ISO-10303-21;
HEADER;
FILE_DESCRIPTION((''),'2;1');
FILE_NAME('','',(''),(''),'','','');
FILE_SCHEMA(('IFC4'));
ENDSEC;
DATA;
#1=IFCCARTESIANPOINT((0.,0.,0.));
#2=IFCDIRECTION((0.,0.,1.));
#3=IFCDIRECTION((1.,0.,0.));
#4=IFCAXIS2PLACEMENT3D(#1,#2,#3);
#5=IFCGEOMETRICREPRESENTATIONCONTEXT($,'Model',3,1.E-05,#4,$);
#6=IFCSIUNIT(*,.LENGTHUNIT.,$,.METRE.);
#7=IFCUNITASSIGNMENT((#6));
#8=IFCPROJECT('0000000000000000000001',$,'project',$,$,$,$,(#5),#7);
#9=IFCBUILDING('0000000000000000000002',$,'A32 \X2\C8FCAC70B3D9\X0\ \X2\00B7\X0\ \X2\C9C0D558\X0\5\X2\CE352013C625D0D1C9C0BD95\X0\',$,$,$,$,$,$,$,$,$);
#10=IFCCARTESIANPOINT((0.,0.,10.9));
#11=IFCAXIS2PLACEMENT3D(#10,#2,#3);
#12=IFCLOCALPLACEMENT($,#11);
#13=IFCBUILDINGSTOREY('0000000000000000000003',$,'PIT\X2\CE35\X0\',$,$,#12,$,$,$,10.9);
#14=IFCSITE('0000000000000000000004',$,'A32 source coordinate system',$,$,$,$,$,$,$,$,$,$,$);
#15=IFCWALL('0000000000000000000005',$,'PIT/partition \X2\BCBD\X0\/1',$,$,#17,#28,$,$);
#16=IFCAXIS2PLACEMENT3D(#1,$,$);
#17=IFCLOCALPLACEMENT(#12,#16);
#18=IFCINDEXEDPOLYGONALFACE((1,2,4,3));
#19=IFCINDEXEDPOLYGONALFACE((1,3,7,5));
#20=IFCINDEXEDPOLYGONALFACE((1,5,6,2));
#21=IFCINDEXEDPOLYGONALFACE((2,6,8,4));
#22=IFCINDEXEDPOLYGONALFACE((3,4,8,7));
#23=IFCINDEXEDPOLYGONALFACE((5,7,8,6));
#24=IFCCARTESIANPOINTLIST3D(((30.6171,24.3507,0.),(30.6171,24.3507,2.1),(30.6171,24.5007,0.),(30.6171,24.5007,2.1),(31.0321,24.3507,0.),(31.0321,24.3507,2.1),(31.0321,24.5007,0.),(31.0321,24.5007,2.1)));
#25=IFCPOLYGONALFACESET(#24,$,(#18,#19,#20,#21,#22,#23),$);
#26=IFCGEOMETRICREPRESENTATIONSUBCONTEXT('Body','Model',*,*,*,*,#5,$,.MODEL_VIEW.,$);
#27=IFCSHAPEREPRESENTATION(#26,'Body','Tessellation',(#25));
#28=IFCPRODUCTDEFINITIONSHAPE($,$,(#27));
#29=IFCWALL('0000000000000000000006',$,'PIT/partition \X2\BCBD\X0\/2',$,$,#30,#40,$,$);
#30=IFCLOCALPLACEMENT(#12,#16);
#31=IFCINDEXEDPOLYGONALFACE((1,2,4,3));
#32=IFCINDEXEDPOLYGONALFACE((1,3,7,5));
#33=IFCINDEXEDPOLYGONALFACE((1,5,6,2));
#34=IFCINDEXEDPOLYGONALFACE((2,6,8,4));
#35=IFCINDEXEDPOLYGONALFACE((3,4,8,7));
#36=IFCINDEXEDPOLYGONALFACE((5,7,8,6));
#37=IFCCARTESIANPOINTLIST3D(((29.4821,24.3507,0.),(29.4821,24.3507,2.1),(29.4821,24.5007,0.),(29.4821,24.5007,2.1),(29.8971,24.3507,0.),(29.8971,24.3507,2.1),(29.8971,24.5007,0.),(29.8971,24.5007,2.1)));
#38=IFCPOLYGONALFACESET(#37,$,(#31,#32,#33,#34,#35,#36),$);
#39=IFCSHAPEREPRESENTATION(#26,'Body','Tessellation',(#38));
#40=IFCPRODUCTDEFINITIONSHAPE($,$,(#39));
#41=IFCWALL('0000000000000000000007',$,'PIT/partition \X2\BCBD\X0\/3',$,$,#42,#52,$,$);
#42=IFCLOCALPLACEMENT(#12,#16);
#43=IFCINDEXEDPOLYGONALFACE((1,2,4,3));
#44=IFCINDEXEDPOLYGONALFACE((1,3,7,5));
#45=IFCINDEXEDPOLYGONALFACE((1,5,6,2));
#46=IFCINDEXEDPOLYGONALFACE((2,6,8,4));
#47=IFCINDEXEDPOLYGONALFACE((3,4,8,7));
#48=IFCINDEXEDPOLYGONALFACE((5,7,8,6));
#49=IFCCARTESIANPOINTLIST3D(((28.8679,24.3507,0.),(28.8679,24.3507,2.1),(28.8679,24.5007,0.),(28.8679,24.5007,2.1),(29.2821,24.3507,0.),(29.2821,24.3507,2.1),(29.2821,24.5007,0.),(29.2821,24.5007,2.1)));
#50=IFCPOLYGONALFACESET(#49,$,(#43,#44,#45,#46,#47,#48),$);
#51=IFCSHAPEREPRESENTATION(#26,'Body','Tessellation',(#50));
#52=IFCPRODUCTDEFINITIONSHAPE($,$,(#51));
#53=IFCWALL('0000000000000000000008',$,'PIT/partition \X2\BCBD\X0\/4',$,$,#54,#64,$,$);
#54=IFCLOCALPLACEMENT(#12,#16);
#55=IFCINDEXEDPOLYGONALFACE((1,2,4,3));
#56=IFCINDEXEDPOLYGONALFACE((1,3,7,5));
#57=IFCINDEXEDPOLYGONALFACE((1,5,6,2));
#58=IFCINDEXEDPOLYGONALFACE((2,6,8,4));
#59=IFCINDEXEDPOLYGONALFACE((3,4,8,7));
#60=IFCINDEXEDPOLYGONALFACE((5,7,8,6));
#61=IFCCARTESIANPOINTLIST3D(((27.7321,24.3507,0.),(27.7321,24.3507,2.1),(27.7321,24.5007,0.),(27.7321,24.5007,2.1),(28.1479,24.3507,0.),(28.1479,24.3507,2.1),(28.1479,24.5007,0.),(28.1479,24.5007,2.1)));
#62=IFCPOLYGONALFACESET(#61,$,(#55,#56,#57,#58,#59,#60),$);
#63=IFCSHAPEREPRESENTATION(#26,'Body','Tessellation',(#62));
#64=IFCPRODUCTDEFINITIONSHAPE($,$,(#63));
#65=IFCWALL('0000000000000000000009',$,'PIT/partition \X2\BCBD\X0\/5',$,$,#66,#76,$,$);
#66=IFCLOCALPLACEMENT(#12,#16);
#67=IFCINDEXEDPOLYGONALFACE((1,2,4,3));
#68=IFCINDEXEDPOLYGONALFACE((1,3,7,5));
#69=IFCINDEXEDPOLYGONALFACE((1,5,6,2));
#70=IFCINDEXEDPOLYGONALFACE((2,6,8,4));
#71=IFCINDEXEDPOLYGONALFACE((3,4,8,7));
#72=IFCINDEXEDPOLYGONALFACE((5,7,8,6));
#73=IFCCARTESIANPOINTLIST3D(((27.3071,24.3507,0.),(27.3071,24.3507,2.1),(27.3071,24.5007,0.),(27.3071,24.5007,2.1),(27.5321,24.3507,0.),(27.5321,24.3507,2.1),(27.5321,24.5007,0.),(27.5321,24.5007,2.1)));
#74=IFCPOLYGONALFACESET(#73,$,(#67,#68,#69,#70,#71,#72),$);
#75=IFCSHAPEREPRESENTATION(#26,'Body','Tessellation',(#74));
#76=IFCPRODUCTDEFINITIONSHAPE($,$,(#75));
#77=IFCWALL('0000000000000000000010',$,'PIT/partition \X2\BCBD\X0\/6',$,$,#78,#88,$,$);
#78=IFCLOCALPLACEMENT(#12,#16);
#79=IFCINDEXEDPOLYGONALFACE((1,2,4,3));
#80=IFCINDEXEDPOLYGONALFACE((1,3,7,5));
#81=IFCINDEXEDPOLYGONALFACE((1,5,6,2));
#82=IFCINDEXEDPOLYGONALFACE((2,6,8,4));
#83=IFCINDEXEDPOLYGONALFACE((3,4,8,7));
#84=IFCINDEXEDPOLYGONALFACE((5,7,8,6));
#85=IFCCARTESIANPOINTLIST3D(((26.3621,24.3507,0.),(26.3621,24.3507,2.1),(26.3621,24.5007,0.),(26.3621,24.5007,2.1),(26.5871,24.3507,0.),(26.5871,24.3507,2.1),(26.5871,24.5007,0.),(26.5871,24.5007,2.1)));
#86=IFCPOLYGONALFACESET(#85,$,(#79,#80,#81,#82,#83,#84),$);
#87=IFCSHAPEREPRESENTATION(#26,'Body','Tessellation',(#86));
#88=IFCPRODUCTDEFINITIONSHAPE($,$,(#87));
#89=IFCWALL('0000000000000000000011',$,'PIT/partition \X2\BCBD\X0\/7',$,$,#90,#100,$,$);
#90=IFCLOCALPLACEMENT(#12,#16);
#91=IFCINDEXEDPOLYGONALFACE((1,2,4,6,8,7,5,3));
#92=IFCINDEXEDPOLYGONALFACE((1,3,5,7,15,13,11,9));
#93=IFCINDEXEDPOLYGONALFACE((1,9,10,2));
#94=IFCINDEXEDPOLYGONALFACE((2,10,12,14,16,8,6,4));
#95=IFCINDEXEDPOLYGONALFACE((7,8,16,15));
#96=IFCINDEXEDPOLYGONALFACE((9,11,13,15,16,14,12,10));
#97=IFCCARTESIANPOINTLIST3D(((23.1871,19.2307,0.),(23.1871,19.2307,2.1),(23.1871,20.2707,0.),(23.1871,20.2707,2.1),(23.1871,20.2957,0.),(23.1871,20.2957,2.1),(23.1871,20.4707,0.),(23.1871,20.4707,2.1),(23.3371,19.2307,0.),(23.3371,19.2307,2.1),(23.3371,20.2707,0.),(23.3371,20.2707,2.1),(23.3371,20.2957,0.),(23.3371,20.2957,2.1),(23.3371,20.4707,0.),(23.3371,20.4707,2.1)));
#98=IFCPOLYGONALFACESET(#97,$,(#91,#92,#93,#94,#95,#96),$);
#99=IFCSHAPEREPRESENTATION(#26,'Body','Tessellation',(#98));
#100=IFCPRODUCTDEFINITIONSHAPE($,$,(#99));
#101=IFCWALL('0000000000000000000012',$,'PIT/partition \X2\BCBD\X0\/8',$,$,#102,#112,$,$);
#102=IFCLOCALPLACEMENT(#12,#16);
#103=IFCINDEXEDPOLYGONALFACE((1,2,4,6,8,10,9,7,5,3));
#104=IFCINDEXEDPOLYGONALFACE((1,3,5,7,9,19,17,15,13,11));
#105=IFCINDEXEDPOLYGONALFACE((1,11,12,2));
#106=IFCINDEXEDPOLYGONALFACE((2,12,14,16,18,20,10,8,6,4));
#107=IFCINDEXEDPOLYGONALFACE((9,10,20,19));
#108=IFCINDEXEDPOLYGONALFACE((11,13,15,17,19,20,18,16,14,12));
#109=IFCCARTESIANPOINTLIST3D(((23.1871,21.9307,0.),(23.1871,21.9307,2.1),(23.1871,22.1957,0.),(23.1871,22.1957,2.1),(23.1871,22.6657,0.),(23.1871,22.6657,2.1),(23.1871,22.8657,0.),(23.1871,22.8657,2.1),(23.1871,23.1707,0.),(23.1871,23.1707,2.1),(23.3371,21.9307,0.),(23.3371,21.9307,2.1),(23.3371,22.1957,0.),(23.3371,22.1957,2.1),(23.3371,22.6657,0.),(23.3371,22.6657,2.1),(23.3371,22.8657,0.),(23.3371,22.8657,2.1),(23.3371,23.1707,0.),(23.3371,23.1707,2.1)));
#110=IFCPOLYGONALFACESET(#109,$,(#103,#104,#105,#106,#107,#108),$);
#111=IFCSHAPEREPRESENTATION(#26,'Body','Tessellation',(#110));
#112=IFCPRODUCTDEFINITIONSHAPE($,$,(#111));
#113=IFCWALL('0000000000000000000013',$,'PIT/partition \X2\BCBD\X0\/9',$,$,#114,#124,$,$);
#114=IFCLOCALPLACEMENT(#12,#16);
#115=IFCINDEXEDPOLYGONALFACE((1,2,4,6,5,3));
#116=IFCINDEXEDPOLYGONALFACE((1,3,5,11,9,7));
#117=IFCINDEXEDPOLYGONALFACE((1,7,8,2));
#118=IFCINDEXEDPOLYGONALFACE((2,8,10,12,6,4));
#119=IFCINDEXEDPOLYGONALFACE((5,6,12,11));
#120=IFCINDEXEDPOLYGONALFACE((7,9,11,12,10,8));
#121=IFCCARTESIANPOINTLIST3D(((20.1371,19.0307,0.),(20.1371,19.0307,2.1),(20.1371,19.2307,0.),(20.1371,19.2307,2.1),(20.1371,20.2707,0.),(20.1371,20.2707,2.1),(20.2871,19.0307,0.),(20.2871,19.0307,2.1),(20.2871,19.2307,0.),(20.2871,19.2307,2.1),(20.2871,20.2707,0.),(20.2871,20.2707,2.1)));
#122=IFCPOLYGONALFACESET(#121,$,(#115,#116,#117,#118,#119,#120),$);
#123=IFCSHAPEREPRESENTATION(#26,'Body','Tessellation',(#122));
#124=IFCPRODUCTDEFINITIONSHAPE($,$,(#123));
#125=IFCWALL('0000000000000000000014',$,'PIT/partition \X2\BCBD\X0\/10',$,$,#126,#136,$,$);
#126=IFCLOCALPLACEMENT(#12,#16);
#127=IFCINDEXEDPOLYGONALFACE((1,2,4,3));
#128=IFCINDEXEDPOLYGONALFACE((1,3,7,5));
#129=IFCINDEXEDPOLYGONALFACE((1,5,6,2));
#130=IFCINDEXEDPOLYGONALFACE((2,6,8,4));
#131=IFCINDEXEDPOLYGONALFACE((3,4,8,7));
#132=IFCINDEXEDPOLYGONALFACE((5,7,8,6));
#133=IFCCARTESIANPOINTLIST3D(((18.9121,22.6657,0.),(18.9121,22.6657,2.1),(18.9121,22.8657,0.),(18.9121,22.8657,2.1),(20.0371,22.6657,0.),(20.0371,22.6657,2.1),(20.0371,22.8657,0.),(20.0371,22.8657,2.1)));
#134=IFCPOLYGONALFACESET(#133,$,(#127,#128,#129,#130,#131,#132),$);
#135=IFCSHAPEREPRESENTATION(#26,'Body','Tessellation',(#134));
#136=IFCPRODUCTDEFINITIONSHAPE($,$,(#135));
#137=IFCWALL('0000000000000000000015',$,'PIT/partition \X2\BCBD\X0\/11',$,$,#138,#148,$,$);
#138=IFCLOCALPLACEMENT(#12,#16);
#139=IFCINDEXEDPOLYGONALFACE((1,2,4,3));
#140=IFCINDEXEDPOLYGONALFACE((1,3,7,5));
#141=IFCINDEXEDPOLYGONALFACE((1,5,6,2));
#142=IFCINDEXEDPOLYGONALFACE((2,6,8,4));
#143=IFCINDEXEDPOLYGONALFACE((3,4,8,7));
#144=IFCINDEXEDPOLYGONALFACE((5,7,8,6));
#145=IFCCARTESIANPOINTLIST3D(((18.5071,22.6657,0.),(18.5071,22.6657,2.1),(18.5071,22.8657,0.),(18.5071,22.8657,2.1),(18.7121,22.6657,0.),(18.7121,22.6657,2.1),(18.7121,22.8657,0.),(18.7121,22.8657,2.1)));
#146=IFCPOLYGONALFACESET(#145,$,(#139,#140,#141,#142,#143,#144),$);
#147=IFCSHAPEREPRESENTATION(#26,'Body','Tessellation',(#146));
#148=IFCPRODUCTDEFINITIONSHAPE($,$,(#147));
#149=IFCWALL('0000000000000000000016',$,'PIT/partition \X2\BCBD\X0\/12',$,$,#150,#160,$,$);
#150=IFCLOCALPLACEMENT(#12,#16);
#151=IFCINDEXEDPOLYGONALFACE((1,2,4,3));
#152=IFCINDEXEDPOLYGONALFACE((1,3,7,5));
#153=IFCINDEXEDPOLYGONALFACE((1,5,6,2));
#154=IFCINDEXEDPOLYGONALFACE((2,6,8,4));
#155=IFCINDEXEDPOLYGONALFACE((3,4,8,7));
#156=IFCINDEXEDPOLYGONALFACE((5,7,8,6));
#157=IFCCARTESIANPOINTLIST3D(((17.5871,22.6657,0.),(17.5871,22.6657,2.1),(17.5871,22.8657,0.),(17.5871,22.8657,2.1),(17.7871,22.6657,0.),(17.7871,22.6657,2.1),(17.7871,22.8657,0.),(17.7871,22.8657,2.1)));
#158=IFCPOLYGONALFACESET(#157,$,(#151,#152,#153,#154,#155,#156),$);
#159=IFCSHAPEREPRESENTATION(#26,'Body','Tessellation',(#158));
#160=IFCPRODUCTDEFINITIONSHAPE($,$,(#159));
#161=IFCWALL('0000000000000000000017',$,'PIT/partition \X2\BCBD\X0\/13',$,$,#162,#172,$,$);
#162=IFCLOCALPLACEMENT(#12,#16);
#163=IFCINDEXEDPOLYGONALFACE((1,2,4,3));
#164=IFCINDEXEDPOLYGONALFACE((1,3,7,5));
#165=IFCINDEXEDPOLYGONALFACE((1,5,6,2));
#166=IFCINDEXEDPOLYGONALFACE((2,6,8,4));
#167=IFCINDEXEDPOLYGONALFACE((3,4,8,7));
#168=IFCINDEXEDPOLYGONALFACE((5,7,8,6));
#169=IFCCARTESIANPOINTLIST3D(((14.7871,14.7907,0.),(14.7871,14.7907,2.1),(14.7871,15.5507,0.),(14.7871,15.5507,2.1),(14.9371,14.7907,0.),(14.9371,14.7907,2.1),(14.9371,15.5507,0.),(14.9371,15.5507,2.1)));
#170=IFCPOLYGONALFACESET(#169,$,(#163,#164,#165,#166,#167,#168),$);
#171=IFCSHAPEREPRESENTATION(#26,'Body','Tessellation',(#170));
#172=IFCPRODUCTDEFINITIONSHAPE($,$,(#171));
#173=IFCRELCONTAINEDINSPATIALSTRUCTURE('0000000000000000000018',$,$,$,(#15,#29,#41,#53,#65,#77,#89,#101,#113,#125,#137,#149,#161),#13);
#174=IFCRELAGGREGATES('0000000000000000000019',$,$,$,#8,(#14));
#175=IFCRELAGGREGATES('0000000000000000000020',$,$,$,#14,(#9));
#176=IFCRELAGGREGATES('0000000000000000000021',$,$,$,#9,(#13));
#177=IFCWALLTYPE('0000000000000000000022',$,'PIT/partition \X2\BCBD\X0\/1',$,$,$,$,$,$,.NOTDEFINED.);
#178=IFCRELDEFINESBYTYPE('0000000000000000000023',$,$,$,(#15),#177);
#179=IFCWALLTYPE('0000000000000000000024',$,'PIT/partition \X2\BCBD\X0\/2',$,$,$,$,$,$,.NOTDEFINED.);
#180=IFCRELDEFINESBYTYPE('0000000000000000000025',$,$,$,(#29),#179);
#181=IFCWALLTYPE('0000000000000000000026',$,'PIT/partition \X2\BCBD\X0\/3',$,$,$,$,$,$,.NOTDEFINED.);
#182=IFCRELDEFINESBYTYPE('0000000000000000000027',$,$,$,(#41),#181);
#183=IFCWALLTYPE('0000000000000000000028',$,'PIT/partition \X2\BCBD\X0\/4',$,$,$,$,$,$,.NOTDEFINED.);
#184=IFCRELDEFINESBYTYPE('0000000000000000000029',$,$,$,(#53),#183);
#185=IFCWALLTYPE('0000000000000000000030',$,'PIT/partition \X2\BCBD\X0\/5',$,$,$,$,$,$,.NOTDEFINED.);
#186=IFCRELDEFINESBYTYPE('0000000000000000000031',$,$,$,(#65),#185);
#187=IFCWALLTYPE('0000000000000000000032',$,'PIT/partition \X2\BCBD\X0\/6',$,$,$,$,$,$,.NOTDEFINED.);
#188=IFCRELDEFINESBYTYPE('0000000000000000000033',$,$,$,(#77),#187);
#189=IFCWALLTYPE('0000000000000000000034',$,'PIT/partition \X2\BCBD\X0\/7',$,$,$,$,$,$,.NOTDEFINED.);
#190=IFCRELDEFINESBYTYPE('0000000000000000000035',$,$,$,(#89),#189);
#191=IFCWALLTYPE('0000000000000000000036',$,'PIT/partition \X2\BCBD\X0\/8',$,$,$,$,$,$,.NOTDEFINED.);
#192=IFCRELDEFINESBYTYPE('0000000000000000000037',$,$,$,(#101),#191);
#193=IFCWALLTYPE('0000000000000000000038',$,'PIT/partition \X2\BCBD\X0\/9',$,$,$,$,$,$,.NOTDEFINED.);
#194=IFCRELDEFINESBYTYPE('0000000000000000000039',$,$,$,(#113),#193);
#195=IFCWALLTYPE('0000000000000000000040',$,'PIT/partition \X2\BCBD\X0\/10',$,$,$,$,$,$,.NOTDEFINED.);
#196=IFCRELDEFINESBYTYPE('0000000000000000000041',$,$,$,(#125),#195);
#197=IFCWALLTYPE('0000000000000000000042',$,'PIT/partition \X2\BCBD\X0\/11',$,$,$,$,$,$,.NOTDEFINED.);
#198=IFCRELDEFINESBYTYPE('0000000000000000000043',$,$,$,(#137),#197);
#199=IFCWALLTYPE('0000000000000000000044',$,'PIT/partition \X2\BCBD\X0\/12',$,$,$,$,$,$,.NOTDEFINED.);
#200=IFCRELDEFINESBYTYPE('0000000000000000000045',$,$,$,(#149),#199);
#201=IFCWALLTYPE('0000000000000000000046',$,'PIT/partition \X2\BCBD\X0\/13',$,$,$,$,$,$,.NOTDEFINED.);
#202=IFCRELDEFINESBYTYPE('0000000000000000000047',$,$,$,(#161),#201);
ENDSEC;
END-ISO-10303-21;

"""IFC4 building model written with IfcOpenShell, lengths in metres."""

from ifc_helpers import new_model, si_unit, frame, origin, origin_with_axes, place, context, subcontext, project, spatial, polyline, outline, extrude, source, transform, mapped, type_object, type_shapes, element, save


model = new_model("IFC4")

# Units and contexts
model_context = context("Model", 3, precision=1e-05, world=origin_with_axes())
body_context = subcontext(model_context, "Body", "Model", "MODEL_VIEW")
ifc_project = project(units=[si_unit("LENGTHUNIT", "METRE")], contexts=[model_context])

# Site, building, storey
site = spatial("IfcSite", under=ifc_project, Name="A32 source coordinate system")
building = spatial("IfcBuilding", under=site, Name="A32 주거동 · 지하5층–옥탑지붕")
storey_placement = place(None, frame((0.0, 0.0, 10.9), z_axis=(0.0, 0.0, 1.0), x_axis=(1.0, 0.0, 0.0)))
storey = spatial("IfcBuildingStorey", under=building, at=storey_placement, Name="PIT층", Elevation=10.9)

# Walls
wall_type_1 = type_object("IfcWallType", Name="PIT/partition 벽/1", PredefinedType="NOTDEFINED")
shared_shape_1 = source(origin(), body_context, "Body", "SweptSolid", [
    extrude(outline(polyline([(30.6171, 24.5007), (31.0321, 24.5007), (31.0321, 24.3507), (30.6171, 24.3507), (30.6171, 24.5007)])), origin(), (0.0, 0.0, 1.0), 2.1),
])
type_shapes(wall_type_1, [shared_shape_1])
wall_1_placement = place(storey_placement, origin_with_axes())
element("IfcWall", 1, at=wall_1_placement, inside=storey, type_object=wall_type_1, Name="PIT/partition 벽/1", context=body_context, shape_type="MappedRepresentation", body=[
    mapped(shared_shape_1, transform((0.0, 0.0, 0.0), scale=1.0)),
])
wall_type_2 = type_object("IfcWallType", Name="PIT/partition 벽/2", PredefinedType="NOTDEFINED")
shared_shape_2 = source(origin(), body_context, "Body", "SweptSolid", [
    extrude(outline(polyline([(29.4821, 24.5007), (29.8971, 24.5007), (29.8971, 24.3507), (29.4821, 24.3507), (29.4821, 24.5007)])), origin(), (0.0, 0.0, 1.0), 2.1),
])
type_shapes(wall_type_2, [shared_shape_2])
wall_2_placement = place(storey_placement, origin_with_axes())
element("IfcWall", 2, at=wall_2_placement, inside=storey, type_object=wall_type_2, Name="PIT/partition 벽/2", context=body_context, shape_type="MappedRepresentation", body=[
    mapped(shared_shape_2, transform((0.0, 0.0, 0.0), scale=1.0)),
])
wall_type_3 = type_object("IfcWallType", Name="PIT/partition 벽/3", PredefinedType="NOTDEFINED")
shared_shape_3 = source(origin(), body_context, "Body", "SweptSolid", [
    extrude(outline(polyline([(28.8679, 24.3507), (28.8679, 24.5007), (29.2821, 24.5007), (29.2821, 24.3507), (28.8679, 24.3507)])), origin(), (0.0, 0.0, 1.0), 2.1),
])
type_shapes(wall_type_3, [shared_shape_3])
wall_3_placement = place(storey_placement, origin_with_axes())
element("IfcWall", 3, at=wall_3_placement, inside=storey, type_object=wall_type_3, Name="PIT/partition 벽/3", context=body_context, shape_type="MappedRepresentation", body=[
    mapped(shared_shape_3, transform((0.0, 0.0, 0.0), scale=1.0)),
])
wall_type_4 = type_object("IfcWallType", Name="PIT/partition 벽/4", PredefinedType="NOTDEFINED")
shared_shape_4 = source(origin(), body_context, "Body", "SweptSolid", [
    extrude(outline(polyline([(27.7321, 24.5007), (28.1479, 24.5007), (28.1479, 24.3507), (27.7321, 24.3507), (27.7321, 24.5007)])), origin(), (0.0, 0.0, 1.0), 2.1),
])
type_shapes(wall_type_4, [shared_shape_4])
wall_4_placement = place(storey_placement, origin_with_axes())
element("IfcWall", 4, at=wall_4_placement, inside=storey, type_object=wall_type_4, Name="PIT/partition 벽/4", context=body_context, shape_type="MappedRepresentation", body=[
    mapped(shared_shape_4, transform((0.0, 0.0, 0.0), scale=1.0)),
])
wall_type_5 = type_object("IfcWallType", Name="PIT/partition 벽/5", PredefinedType="NOTDEFINED")
shared_shape_5 = source(origin(), body_context, "Body", "SweptSolid", [
    extrude(outline(polyline([(27.3071, 24.5007), (27.5321, 24.5007), (27.5321, 24.3507), (27.3071, 24.3507), (27.3071, 24.5007)])), origin(), (0.0, 0.0, 1.0), 2.1),
])
type_shapes(wall_type_5, [shared_shape_5])
wall_5_placement = place(storey_placement, origin_with_axes())
element("IfcWall", 5, at=wall_5_placement, inside=storey, type_object=wall_type_5, Name="PIT/partition 벽/5", context=body_context, shape_type="MappedRepresentation", body=[
    mapped(shared_shape_5, transform((0.0, 0.0, 0.0), scale=1.0)),
])
wall_type_6 = type_object("IfcWallType", Name="PIT/partition 벽/6", PredefinedType="NOTDEFINED")
shared_shape_6 = source(origin(), body_context, "Body", "SweptSolid", [
    extrude(outline(polyline([(26.3621, 24.3507), (26.3621, 24.5007), (26.5871, 24.5007), (26.5871, 24.3507), (26.3621, 24.3507)])), origin(), (0.0, 0.0, 1.0), 2.1),
])
type_shapes(wall_type_6, [shared_shape_6])
wall_6_placement = place(storey_placement, origin_with_axes())
element("IfcWall", 6, at=wall_6_placement, inside=storey, type_object=wall_type_6, Name="PIT/partition 벽/6", context=body_context, shape_type="MappedRepresentation", body=[
    mapped(shared_shape_6, transform((0.0, 0.0, 0.0), scale=1.0)),
])
wall_type_7 = type_object("IfcWallType", Name="PIT/partition 벽/7", PredefinedType="NOTDEFINED")
shared_shape_7 = source(origin(), body_context, "Body", "SweptSolid", [
    extrude(outline(polyline([(23.1871, 20.2707), (23.1871, 20.2957), (23.1871, 20.4707), (23.3371, 20.4707), (23.3371, 20.2957), (23.3371, 20.2707), (23.3371, 19.2307), (23.1871, 19.2307), (23.1871, 20.2707)])), origin(), (0.0, 0.0, 1.0), 2.1),
])
type_shapes(wall_type_7, [shared_shape_7])
wall_7_placement = place(storey_placement, origin_with_axes())
element("IfcWall", 7, at=wall_7_placement, inside=storey, type_object=wall_type_7, Name="PIT/partition 벽/7", context=body_context, shape_type="MappedRepresentation", body=[
    mapped(shared_shape_7, transform((0.0, 0.0, 0.0), scale=1.0)),
])
wall_type_8 = type_object("IfcWallType", Name="PIT/partition 벽/8", PredefinedType="NOTDEFINED")
shared_shape_8 = source(origin(), body_context, "Body", "SweptSolid", [
    extrude(outline(polyline([(23.1871, 22.6657), (23.1871, 22.8657), (23.1871, 23.1707), (23.3371, 23.1707), (23.3371, 22.8657), (23.3371, 22.6657), (23.3371, 22.1957), (23.3371, 21.9307), (23.1871, 21.9307), (23.1871, 22.1957), (23.1871, 22.6657)])), origin(), (0.0, 0.0, 1.0), 2.1),
])
type_shapes(wall_type_8, [shared_shape_8])
wall_8_placement = place(storey_placement, origin_with_axes())
element("IfcWall", 8, at=wall_8_placement, inside=storey, type_object=wall_type_8, Name="PIT/partition 벽/8", context=body_context, shape_type="MappedRepresentation", body=[
    mapped(shared_shape_8, transform((0.0, 0.0, 0.0), scale=1.0)),
])
wall_type_9 = type_object("IfcWallType", Name="PIT/partition 벽/9", PredefinedType="NOTDEFINED")
shared_shape_9 = source(origin(), body_context, "Body", "SweptSolid", [
    extrude(outline(polyline([(20.2871, 20.2707), (20.2871, 19.2307), (20.2871, 19.0307), (20.1371, 19.0307), (20.1371, 19.2307), (20.1371, 20.2707), (20.2871, 20.2707)])), origin(), (0.0, 0.0, 1.0), 2.1),
])
type_shapes(wall_type_9, [shared_shape_9])
wall_9_placement = place(storey_placement, origin_with_axes())
element("IfcWall", 9, at=wall_9_placement, inside=storey, type_object=wall_type_9, Name="PIT/partition 벽/9", context=body_context, shape_type="MappedRepresentation", body=[
    mapped(shared_shape_9, transform((0.0, 0.0, 0.0), scale=1.0)),
])
wall_type_10 = type_object("IfcWallType", Name="PIT/partition 벽/10", PredefinedType="NOTDEFINED")
shared_shape_10 = source(origin(), body_context, "Body", "SweptSolid", [
    extrude(outline(polyline([(18.9121, 22.6657), (18.9121, 22.8657), (20.0371, 22.8657), (20.0371, 22.6657), (18.9121, 22.6657)])), origin(), (0.0, 0.0, 1.0), 2.1),
])
type_shapes(wall_type_10, [shared_shape_10])
wall_10_placement = place(storey_placement, origin_with_axes())
element("IfcWall", 10, at=wall_10_placement, inside=storey, type_object=wall_type_10, Name="PIT/partition 벽/10", context=body_context, shape_type="MappedRepresentation", body=[
    mapped(shared_shape_10, transform((0.0, 0.0, 0.0), scale=1.0)),
])
wall_type_11 = type_object("IfcWallType", Name="PIT/partition 벽/11", PredefinedType="NOTDEFINED")
shared_shape_11 = source(origin(), body_context, "Body", "SweptSolid", [
    extrude(outline(polyline([(18.5071, 22.8657), (18.7121, 22.8657), (18.7121, 22.6657), (18.5071, 22.6657), (18.5071, 22.8657)])), origin(), (0.0, 0.0, 1.0), 2.1),
])
type_shapes(wall_type_11, [shared_shape_11])
wall_11_placement = place(storey_placement, origin_with_axes())
element("IfcWall", 11, at=wall_11_placement, inside=storey, type_object=wall_type_11, Name="PIT/partition 벽/11", context=body_context, shape_type="MappedRepresentation", body=[
    mapped(shared_shape_11, transform((0.0, 0.0, 0.0), scale=1.0)),
])
wall_type_12 = type_object("IfcWallType", Name="PIT/partition 벽/12", PredefinedType="NOTDEFINED")
shared_shape_12 = source(origin(), body_context, "Body", "SweptSolid", [
    extrude(outline(polyline([(17.5871, 22.8657), (17.7871, 22.8657), (17.7871, 22.6657), (17.5871, 22.6657), (17.5871, 22.8657)])), origin(), (0.0, 0.0, 1.0), 2.1),
])
type_shapes(wall_type_12, [shared_shape_12])
wall_12_placement = place(storey_placement, origin_with_axes())
element("IfcWall", 12, at=wall_12_placement, inside=storey, type_object=wall_type_12, Name="PIT/partition 벽/12", context=body_context, shape_type="MappedRepresentation", body=[
    mapped(shared_shape_12, transform((0.0, 0.0, 0.0), scale=1.0)),
])
wall_type_13 = type_object("IfcWallType", Name="PIT/partition 벽/13", PredefinedType="NOTDEFINED")
shared_shape_13 = source(origin(), body_context, "Body", "SweptSolid", [
    extrude(outline(polyline([(14.7871, 14.7907), (14.7871, 15.5507), (14.9371, 15.5507), (14.9371, 14.7907), (14.7871, 14.7907)])), origin(), (0.0, 0.0, 1.0), 2.1),
])
type_shapes(wall_type_13, [shared_shape_13])
wall_13_placement = place(storey_placement, origin_with_axes())
element("IfcWall", 13, at=wall_13_placement, inside=storey, type_object=wall_type_13, Name="PIT/partition 벽/13", context=body_context, shape_type="MappedRepresentation", body=[
    mapped(shared_shape_13, transform((0.0, 0.0, 0.0), scale=1.0)),
])

save(model, "model.ifc")
